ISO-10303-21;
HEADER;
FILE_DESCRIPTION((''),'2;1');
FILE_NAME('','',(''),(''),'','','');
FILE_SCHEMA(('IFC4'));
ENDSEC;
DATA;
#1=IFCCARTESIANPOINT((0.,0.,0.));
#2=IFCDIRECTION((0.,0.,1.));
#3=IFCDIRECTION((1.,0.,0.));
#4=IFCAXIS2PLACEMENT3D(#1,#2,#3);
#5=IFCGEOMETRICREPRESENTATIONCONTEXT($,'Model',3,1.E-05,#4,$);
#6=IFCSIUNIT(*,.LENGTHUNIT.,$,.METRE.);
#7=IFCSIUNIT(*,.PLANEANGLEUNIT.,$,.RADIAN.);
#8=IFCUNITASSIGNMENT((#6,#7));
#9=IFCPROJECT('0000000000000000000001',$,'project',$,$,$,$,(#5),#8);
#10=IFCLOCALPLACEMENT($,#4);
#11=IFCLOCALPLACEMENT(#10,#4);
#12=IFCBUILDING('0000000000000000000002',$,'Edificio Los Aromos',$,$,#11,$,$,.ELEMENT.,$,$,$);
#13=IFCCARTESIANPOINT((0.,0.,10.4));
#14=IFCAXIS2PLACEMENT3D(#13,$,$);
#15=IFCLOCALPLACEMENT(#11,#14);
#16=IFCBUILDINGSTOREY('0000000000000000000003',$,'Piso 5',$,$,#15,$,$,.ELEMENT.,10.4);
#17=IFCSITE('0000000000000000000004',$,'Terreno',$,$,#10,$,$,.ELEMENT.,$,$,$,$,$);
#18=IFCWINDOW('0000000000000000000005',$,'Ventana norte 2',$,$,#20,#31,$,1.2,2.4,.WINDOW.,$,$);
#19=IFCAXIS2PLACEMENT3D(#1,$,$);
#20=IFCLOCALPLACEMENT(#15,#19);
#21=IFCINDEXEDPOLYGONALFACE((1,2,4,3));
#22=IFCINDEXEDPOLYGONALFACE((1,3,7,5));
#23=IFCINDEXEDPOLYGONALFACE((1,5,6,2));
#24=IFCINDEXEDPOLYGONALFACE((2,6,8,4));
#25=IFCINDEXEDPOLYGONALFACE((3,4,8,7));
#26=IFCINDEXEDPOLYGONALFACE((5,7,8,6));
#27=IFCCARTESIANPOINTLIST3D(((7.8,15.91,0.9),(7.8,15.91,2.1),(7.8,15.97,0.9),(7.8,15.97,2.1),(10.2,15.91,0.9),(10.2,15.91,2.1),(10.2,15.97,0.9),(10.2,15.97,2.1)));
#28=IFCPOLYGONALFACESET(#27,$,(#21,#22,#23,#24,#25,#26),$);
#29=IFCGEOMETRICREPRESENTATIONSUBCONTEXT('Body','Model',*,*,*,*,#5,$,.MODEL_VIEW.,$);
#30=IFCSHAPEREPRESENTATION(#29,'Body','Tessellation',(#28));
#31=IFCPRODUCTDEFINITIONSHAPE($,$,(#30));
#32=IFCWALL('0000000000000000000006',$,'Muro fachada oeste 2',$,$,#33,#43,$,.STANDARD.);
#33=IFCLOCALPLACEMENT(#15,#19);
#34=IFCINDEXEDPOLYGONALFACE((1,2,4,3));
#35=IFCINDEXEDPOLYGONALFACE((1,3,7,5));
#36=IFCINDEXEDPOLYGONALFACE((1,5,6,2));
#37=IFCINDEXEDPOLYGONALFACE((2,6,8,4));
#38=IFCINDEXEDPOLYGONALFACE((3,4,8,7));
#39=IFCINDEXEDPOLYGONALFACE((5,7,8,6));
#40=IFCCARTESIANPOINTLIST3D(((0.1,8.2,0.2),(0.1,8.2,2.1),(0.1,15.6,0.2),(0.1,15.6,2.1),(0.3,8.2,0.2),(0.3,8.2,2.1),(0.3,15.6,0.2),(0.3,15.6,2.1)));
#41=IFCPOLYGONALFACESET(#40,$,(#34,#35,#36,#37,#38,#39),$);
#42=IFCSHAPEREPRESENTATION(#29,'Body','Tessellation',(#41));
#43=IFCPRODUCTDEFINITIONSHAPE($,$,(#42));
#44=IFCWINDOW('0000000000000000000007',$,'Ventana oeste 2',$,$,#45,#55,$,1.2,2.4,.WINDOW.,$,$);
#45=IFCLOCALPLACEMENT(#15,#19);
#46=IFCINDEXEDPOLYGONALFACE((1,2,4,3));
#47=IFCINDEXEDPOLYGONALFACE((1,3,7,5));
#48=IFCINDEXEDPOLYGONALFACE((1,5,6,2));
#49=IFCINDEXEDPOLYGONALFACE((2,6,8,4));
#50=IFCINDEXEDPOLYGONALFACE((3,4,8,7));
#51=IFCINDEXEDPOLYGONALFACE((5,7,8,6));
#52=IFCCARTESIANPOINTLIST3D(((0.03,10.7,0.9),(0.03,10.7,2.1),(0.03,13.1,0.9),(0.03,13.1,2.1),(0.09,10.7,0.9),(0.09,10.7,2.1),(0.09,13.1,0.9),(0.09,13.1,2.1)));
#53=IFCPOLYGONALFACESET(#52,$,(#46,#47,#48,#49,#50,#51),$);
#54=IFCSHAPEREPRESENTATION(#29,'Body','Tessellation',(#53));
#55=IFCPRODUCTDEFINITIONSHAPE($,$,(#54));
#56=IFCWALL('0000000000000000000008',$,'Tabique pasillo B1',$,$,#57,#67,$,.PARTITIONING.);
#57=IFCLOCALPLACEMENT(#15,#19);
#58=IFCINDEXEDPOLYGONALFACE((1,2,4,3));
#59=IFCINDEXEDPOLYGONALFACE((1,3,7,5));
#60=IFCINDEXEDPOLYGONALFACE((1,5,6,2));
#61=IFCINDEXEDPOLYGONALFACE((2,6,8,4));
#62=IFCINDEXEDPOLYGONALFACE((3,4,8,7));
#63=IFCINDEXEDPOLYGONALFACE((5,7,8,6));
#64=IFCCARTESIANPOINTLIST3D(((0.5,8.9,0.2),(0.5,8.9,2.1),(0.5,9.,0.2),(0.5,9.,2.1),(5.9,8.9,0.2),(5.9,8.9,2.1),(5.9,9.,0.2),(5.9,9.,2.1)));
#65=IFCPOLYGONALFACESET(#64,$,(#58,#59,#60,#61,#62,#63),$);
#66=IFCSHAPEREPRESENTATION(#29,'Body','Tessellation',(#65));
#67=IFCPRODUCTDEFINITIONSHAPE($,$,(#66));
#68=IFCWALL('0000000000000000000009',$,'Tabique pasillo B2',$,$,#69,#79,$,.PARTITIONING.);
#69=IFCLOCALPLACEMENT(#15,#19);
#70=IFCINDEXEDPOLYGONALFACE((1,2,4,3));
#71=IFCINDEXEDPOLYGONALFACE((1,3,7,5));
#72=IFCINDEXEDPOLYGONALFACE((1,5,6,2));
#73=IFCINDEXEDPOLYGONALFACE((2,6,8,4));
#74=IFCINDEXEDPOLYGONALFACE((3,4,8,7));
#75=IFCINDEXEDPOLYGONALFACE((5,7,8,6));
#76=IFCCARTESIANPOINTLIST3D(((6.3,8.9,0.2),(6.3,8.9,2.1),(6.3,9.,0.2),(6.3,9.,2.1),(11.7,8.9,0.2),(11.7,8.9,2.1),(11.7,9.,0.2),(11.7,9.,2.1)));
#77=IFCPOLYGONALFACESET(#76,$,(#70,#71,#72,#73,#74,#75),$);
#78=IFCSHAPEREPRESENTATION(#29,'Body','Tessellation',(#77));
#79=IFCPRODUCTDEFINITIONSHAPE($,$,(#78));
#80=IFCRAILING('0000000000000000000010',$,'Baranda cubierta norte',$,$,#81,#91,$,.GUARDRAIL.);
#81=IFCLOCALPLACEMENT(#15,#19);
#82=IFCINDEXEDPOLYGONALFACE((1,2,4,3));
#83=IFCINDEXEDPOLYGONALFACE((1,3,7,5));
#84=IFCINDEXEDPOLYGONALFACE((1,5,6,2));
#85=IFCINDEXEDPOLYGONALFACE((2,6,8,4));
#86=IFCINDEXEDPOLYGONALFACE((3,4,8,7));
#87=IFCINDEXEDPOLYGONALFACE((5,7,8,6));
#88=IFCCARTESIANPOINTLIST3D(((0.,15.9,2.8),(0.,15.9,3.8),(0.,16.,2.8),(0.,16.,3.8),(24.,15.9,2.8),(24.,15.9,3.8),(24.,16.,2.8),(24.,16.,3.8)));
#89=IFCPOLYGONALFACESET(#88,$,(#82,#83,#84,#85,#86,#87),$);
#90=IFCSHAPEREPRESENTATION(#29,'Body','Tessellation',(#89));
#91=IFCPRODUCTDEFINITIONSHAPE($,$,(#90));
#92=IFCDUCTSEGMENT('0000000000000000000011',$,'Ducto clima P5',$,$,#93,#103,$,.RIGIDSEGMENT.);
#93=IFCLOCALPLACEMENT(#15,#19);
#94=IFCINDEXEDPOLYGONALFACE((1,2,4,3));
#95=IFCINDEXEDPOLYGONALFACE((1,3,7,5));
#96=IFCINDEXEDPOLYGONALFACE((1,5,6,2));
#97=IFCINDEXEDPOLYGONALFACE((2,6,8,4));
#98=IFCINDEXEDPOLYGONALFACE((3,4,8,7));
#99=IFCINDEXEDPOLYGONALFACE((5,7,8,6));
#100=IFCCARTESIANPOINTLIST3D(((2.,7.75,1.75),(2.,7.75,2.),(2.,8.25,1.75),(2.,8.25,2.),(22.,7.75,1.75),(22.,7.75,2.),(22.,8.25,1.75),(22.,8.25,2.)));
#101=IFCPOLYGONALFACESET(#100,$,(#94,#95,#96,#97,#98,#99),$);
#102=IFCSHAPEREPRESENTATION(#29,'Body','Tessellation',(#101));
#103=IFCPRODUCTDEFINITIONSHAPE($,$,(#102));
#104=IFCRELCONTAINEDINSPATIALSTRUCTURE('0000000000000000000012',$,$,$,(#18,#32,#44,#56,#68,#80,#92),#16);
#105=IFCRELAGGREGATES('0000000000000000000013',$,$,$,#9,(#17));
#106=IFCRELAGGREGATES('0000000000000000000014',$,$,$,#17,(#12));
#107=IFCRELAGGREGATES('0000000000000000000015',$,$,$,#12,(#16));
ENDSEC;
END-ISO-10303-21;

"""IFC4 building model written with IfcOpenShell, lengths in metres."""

from ifc_helpers import new_model, si_unit, frame, frame_2d, origin_with_axes, place, context, subcontext, project, spatial, rectangle, extrude, element, save


model = new_model("IFC4")

# Units and contexts
model_context = context("Model", 3, precision=1e-05, world=origin_with_axes())
body_context = subcontext(model_context, "Body", "Model", "MODEL_VIEW")
ifc_project = project(units=[si_unit("LENGTHUNIT", "METRE"), si_unit("PLANEANGLEUNIT", "RADIAN")], contexts=[model_context])

# Site, building, storey
site_placement = place(None, origin_with_axes())
site = spatial("IfcSite", under=ifc_project, at=site_placement, Name="Terreno", CompositionType="ELEMENT")
building_placement = place(site_placement, origin_with_axes())
building = spatial("IfcBuilding", under=site, at=building_placement, Name="Edificio Los Aromos", CompositionType="ELEMENT")
storey_placement = place(building_placement, frame((0.0, 0.0, 10.4)))
storey = spatial("IfcBuildingStorey", under=building, at=storey_placement, Name="Piso 5", CompositionType="ELEMENT", Elevation=10.4)

# Window
window_1_placement = place(storey_placement, frame((7.8, 15.91, 0.9)))
element("IfcWindow", 1, at=window_1_placement, inside=storey, Name="Ventana norte 2", OverallHeight=1.2, OverallWidth=2.4, PredefinedType="WINDOW", context=body_context, shape_type="SweptSolid", body=[
    extrude(rectangle(XDim=2.4, YDim=0.06, at=frame_2d((1.2, 0.03))), origin_with_axes(), (0.0, 0.0, 1.0), 1.2),
])

# Wall
wall_1_placement = place(storey_placement, frame((0.1, 8.2, 0.2)))
element("IfcWall", 2, at=wall_1_placement, inside=storey, Name="Muro fachada oeste 2", PredefinedType="STANDARD", context=body_context, shape_type="SweptSolid", body=[
    extrude(rectangle(XDim=0.2, YDim=7.4, at=frame_2d((0.1, 3.7))), origin_with_axes(), (0.0, 0.0, 1.0), 1.9),
])

# Window
window_2_placement = place(storey_placement, frame((0.03, 10.7, 0.9)))
element("IfcWindow", 3, at=window_2_placement, inside=storey, Name="Ventana oeste 2", OverallHeight=1.2, OverallWidth=2.4, PredefinedType="WINDOW", context=body_context, shape_type="SweptSolid", body=[
    extrude(rectangle(XDim=0.06, YDim=2.4, at=frame_2d((0.03, 1.2))), origin_with_axes(), (0.0, 0.0, 1.0), 1.2),
])

# Walls
for number, where, name in (
    (4, (0.5, 8.9, 0.2), "Tabique pasillo B1"),
    (5, (6.3, 8.9, 0.2), "Tabique pasillo B2"),
):
    element("IfcWall", number, at=place(storey_placement, frame(where)), inside=storey, Name=name, PredefinedType="PARTITIONING", context=body_context, shape_type="SweptSolid", body=[
        extrude(rectangle(XDim=5.4, YDim=0.1, at=frame_2d((2.7, 0.05))), origin_with_axes(), (0.0, 0.0, 1.0), 1.9),
    ])

# Railing
railing_placement = place(storey_placement, frame((0.0, 15.9, 2.8)))
element("IfcRailing", 6, at=railing_placement, inside=storey, Name="Baranda cubierta norte", PredefinedType="GUARDRAIL", context=body_context, shape_type="SweptSolid", body=[
    extrude(rectangle(XDim=24.0, YDim=0.1, at=frame_2d((12.0, 0.05))), origin_with_axes(), (0.0, 0.0, 1.0), 1.0),
])

# Duct segment
duct_segment_placement = place(storey_placement, frame((2.0, 7.75, 1.75)))
element("IfcDuctSegment", 7, at=duct_segment_placement, inside=storey, Name="Ducto clima P5", PredefinedType="RIGIDSEGMENT", context=body_context, shape_type="SweptSolid", body=[
    extrude(rectangle(XDim=20.0, YDim=0.5, at=frame_2d((10.0, 0.25))), origin_with_axes(), (0.0, 0.0, 1.0), 0.25),
])

save(model, "model.ifc")
